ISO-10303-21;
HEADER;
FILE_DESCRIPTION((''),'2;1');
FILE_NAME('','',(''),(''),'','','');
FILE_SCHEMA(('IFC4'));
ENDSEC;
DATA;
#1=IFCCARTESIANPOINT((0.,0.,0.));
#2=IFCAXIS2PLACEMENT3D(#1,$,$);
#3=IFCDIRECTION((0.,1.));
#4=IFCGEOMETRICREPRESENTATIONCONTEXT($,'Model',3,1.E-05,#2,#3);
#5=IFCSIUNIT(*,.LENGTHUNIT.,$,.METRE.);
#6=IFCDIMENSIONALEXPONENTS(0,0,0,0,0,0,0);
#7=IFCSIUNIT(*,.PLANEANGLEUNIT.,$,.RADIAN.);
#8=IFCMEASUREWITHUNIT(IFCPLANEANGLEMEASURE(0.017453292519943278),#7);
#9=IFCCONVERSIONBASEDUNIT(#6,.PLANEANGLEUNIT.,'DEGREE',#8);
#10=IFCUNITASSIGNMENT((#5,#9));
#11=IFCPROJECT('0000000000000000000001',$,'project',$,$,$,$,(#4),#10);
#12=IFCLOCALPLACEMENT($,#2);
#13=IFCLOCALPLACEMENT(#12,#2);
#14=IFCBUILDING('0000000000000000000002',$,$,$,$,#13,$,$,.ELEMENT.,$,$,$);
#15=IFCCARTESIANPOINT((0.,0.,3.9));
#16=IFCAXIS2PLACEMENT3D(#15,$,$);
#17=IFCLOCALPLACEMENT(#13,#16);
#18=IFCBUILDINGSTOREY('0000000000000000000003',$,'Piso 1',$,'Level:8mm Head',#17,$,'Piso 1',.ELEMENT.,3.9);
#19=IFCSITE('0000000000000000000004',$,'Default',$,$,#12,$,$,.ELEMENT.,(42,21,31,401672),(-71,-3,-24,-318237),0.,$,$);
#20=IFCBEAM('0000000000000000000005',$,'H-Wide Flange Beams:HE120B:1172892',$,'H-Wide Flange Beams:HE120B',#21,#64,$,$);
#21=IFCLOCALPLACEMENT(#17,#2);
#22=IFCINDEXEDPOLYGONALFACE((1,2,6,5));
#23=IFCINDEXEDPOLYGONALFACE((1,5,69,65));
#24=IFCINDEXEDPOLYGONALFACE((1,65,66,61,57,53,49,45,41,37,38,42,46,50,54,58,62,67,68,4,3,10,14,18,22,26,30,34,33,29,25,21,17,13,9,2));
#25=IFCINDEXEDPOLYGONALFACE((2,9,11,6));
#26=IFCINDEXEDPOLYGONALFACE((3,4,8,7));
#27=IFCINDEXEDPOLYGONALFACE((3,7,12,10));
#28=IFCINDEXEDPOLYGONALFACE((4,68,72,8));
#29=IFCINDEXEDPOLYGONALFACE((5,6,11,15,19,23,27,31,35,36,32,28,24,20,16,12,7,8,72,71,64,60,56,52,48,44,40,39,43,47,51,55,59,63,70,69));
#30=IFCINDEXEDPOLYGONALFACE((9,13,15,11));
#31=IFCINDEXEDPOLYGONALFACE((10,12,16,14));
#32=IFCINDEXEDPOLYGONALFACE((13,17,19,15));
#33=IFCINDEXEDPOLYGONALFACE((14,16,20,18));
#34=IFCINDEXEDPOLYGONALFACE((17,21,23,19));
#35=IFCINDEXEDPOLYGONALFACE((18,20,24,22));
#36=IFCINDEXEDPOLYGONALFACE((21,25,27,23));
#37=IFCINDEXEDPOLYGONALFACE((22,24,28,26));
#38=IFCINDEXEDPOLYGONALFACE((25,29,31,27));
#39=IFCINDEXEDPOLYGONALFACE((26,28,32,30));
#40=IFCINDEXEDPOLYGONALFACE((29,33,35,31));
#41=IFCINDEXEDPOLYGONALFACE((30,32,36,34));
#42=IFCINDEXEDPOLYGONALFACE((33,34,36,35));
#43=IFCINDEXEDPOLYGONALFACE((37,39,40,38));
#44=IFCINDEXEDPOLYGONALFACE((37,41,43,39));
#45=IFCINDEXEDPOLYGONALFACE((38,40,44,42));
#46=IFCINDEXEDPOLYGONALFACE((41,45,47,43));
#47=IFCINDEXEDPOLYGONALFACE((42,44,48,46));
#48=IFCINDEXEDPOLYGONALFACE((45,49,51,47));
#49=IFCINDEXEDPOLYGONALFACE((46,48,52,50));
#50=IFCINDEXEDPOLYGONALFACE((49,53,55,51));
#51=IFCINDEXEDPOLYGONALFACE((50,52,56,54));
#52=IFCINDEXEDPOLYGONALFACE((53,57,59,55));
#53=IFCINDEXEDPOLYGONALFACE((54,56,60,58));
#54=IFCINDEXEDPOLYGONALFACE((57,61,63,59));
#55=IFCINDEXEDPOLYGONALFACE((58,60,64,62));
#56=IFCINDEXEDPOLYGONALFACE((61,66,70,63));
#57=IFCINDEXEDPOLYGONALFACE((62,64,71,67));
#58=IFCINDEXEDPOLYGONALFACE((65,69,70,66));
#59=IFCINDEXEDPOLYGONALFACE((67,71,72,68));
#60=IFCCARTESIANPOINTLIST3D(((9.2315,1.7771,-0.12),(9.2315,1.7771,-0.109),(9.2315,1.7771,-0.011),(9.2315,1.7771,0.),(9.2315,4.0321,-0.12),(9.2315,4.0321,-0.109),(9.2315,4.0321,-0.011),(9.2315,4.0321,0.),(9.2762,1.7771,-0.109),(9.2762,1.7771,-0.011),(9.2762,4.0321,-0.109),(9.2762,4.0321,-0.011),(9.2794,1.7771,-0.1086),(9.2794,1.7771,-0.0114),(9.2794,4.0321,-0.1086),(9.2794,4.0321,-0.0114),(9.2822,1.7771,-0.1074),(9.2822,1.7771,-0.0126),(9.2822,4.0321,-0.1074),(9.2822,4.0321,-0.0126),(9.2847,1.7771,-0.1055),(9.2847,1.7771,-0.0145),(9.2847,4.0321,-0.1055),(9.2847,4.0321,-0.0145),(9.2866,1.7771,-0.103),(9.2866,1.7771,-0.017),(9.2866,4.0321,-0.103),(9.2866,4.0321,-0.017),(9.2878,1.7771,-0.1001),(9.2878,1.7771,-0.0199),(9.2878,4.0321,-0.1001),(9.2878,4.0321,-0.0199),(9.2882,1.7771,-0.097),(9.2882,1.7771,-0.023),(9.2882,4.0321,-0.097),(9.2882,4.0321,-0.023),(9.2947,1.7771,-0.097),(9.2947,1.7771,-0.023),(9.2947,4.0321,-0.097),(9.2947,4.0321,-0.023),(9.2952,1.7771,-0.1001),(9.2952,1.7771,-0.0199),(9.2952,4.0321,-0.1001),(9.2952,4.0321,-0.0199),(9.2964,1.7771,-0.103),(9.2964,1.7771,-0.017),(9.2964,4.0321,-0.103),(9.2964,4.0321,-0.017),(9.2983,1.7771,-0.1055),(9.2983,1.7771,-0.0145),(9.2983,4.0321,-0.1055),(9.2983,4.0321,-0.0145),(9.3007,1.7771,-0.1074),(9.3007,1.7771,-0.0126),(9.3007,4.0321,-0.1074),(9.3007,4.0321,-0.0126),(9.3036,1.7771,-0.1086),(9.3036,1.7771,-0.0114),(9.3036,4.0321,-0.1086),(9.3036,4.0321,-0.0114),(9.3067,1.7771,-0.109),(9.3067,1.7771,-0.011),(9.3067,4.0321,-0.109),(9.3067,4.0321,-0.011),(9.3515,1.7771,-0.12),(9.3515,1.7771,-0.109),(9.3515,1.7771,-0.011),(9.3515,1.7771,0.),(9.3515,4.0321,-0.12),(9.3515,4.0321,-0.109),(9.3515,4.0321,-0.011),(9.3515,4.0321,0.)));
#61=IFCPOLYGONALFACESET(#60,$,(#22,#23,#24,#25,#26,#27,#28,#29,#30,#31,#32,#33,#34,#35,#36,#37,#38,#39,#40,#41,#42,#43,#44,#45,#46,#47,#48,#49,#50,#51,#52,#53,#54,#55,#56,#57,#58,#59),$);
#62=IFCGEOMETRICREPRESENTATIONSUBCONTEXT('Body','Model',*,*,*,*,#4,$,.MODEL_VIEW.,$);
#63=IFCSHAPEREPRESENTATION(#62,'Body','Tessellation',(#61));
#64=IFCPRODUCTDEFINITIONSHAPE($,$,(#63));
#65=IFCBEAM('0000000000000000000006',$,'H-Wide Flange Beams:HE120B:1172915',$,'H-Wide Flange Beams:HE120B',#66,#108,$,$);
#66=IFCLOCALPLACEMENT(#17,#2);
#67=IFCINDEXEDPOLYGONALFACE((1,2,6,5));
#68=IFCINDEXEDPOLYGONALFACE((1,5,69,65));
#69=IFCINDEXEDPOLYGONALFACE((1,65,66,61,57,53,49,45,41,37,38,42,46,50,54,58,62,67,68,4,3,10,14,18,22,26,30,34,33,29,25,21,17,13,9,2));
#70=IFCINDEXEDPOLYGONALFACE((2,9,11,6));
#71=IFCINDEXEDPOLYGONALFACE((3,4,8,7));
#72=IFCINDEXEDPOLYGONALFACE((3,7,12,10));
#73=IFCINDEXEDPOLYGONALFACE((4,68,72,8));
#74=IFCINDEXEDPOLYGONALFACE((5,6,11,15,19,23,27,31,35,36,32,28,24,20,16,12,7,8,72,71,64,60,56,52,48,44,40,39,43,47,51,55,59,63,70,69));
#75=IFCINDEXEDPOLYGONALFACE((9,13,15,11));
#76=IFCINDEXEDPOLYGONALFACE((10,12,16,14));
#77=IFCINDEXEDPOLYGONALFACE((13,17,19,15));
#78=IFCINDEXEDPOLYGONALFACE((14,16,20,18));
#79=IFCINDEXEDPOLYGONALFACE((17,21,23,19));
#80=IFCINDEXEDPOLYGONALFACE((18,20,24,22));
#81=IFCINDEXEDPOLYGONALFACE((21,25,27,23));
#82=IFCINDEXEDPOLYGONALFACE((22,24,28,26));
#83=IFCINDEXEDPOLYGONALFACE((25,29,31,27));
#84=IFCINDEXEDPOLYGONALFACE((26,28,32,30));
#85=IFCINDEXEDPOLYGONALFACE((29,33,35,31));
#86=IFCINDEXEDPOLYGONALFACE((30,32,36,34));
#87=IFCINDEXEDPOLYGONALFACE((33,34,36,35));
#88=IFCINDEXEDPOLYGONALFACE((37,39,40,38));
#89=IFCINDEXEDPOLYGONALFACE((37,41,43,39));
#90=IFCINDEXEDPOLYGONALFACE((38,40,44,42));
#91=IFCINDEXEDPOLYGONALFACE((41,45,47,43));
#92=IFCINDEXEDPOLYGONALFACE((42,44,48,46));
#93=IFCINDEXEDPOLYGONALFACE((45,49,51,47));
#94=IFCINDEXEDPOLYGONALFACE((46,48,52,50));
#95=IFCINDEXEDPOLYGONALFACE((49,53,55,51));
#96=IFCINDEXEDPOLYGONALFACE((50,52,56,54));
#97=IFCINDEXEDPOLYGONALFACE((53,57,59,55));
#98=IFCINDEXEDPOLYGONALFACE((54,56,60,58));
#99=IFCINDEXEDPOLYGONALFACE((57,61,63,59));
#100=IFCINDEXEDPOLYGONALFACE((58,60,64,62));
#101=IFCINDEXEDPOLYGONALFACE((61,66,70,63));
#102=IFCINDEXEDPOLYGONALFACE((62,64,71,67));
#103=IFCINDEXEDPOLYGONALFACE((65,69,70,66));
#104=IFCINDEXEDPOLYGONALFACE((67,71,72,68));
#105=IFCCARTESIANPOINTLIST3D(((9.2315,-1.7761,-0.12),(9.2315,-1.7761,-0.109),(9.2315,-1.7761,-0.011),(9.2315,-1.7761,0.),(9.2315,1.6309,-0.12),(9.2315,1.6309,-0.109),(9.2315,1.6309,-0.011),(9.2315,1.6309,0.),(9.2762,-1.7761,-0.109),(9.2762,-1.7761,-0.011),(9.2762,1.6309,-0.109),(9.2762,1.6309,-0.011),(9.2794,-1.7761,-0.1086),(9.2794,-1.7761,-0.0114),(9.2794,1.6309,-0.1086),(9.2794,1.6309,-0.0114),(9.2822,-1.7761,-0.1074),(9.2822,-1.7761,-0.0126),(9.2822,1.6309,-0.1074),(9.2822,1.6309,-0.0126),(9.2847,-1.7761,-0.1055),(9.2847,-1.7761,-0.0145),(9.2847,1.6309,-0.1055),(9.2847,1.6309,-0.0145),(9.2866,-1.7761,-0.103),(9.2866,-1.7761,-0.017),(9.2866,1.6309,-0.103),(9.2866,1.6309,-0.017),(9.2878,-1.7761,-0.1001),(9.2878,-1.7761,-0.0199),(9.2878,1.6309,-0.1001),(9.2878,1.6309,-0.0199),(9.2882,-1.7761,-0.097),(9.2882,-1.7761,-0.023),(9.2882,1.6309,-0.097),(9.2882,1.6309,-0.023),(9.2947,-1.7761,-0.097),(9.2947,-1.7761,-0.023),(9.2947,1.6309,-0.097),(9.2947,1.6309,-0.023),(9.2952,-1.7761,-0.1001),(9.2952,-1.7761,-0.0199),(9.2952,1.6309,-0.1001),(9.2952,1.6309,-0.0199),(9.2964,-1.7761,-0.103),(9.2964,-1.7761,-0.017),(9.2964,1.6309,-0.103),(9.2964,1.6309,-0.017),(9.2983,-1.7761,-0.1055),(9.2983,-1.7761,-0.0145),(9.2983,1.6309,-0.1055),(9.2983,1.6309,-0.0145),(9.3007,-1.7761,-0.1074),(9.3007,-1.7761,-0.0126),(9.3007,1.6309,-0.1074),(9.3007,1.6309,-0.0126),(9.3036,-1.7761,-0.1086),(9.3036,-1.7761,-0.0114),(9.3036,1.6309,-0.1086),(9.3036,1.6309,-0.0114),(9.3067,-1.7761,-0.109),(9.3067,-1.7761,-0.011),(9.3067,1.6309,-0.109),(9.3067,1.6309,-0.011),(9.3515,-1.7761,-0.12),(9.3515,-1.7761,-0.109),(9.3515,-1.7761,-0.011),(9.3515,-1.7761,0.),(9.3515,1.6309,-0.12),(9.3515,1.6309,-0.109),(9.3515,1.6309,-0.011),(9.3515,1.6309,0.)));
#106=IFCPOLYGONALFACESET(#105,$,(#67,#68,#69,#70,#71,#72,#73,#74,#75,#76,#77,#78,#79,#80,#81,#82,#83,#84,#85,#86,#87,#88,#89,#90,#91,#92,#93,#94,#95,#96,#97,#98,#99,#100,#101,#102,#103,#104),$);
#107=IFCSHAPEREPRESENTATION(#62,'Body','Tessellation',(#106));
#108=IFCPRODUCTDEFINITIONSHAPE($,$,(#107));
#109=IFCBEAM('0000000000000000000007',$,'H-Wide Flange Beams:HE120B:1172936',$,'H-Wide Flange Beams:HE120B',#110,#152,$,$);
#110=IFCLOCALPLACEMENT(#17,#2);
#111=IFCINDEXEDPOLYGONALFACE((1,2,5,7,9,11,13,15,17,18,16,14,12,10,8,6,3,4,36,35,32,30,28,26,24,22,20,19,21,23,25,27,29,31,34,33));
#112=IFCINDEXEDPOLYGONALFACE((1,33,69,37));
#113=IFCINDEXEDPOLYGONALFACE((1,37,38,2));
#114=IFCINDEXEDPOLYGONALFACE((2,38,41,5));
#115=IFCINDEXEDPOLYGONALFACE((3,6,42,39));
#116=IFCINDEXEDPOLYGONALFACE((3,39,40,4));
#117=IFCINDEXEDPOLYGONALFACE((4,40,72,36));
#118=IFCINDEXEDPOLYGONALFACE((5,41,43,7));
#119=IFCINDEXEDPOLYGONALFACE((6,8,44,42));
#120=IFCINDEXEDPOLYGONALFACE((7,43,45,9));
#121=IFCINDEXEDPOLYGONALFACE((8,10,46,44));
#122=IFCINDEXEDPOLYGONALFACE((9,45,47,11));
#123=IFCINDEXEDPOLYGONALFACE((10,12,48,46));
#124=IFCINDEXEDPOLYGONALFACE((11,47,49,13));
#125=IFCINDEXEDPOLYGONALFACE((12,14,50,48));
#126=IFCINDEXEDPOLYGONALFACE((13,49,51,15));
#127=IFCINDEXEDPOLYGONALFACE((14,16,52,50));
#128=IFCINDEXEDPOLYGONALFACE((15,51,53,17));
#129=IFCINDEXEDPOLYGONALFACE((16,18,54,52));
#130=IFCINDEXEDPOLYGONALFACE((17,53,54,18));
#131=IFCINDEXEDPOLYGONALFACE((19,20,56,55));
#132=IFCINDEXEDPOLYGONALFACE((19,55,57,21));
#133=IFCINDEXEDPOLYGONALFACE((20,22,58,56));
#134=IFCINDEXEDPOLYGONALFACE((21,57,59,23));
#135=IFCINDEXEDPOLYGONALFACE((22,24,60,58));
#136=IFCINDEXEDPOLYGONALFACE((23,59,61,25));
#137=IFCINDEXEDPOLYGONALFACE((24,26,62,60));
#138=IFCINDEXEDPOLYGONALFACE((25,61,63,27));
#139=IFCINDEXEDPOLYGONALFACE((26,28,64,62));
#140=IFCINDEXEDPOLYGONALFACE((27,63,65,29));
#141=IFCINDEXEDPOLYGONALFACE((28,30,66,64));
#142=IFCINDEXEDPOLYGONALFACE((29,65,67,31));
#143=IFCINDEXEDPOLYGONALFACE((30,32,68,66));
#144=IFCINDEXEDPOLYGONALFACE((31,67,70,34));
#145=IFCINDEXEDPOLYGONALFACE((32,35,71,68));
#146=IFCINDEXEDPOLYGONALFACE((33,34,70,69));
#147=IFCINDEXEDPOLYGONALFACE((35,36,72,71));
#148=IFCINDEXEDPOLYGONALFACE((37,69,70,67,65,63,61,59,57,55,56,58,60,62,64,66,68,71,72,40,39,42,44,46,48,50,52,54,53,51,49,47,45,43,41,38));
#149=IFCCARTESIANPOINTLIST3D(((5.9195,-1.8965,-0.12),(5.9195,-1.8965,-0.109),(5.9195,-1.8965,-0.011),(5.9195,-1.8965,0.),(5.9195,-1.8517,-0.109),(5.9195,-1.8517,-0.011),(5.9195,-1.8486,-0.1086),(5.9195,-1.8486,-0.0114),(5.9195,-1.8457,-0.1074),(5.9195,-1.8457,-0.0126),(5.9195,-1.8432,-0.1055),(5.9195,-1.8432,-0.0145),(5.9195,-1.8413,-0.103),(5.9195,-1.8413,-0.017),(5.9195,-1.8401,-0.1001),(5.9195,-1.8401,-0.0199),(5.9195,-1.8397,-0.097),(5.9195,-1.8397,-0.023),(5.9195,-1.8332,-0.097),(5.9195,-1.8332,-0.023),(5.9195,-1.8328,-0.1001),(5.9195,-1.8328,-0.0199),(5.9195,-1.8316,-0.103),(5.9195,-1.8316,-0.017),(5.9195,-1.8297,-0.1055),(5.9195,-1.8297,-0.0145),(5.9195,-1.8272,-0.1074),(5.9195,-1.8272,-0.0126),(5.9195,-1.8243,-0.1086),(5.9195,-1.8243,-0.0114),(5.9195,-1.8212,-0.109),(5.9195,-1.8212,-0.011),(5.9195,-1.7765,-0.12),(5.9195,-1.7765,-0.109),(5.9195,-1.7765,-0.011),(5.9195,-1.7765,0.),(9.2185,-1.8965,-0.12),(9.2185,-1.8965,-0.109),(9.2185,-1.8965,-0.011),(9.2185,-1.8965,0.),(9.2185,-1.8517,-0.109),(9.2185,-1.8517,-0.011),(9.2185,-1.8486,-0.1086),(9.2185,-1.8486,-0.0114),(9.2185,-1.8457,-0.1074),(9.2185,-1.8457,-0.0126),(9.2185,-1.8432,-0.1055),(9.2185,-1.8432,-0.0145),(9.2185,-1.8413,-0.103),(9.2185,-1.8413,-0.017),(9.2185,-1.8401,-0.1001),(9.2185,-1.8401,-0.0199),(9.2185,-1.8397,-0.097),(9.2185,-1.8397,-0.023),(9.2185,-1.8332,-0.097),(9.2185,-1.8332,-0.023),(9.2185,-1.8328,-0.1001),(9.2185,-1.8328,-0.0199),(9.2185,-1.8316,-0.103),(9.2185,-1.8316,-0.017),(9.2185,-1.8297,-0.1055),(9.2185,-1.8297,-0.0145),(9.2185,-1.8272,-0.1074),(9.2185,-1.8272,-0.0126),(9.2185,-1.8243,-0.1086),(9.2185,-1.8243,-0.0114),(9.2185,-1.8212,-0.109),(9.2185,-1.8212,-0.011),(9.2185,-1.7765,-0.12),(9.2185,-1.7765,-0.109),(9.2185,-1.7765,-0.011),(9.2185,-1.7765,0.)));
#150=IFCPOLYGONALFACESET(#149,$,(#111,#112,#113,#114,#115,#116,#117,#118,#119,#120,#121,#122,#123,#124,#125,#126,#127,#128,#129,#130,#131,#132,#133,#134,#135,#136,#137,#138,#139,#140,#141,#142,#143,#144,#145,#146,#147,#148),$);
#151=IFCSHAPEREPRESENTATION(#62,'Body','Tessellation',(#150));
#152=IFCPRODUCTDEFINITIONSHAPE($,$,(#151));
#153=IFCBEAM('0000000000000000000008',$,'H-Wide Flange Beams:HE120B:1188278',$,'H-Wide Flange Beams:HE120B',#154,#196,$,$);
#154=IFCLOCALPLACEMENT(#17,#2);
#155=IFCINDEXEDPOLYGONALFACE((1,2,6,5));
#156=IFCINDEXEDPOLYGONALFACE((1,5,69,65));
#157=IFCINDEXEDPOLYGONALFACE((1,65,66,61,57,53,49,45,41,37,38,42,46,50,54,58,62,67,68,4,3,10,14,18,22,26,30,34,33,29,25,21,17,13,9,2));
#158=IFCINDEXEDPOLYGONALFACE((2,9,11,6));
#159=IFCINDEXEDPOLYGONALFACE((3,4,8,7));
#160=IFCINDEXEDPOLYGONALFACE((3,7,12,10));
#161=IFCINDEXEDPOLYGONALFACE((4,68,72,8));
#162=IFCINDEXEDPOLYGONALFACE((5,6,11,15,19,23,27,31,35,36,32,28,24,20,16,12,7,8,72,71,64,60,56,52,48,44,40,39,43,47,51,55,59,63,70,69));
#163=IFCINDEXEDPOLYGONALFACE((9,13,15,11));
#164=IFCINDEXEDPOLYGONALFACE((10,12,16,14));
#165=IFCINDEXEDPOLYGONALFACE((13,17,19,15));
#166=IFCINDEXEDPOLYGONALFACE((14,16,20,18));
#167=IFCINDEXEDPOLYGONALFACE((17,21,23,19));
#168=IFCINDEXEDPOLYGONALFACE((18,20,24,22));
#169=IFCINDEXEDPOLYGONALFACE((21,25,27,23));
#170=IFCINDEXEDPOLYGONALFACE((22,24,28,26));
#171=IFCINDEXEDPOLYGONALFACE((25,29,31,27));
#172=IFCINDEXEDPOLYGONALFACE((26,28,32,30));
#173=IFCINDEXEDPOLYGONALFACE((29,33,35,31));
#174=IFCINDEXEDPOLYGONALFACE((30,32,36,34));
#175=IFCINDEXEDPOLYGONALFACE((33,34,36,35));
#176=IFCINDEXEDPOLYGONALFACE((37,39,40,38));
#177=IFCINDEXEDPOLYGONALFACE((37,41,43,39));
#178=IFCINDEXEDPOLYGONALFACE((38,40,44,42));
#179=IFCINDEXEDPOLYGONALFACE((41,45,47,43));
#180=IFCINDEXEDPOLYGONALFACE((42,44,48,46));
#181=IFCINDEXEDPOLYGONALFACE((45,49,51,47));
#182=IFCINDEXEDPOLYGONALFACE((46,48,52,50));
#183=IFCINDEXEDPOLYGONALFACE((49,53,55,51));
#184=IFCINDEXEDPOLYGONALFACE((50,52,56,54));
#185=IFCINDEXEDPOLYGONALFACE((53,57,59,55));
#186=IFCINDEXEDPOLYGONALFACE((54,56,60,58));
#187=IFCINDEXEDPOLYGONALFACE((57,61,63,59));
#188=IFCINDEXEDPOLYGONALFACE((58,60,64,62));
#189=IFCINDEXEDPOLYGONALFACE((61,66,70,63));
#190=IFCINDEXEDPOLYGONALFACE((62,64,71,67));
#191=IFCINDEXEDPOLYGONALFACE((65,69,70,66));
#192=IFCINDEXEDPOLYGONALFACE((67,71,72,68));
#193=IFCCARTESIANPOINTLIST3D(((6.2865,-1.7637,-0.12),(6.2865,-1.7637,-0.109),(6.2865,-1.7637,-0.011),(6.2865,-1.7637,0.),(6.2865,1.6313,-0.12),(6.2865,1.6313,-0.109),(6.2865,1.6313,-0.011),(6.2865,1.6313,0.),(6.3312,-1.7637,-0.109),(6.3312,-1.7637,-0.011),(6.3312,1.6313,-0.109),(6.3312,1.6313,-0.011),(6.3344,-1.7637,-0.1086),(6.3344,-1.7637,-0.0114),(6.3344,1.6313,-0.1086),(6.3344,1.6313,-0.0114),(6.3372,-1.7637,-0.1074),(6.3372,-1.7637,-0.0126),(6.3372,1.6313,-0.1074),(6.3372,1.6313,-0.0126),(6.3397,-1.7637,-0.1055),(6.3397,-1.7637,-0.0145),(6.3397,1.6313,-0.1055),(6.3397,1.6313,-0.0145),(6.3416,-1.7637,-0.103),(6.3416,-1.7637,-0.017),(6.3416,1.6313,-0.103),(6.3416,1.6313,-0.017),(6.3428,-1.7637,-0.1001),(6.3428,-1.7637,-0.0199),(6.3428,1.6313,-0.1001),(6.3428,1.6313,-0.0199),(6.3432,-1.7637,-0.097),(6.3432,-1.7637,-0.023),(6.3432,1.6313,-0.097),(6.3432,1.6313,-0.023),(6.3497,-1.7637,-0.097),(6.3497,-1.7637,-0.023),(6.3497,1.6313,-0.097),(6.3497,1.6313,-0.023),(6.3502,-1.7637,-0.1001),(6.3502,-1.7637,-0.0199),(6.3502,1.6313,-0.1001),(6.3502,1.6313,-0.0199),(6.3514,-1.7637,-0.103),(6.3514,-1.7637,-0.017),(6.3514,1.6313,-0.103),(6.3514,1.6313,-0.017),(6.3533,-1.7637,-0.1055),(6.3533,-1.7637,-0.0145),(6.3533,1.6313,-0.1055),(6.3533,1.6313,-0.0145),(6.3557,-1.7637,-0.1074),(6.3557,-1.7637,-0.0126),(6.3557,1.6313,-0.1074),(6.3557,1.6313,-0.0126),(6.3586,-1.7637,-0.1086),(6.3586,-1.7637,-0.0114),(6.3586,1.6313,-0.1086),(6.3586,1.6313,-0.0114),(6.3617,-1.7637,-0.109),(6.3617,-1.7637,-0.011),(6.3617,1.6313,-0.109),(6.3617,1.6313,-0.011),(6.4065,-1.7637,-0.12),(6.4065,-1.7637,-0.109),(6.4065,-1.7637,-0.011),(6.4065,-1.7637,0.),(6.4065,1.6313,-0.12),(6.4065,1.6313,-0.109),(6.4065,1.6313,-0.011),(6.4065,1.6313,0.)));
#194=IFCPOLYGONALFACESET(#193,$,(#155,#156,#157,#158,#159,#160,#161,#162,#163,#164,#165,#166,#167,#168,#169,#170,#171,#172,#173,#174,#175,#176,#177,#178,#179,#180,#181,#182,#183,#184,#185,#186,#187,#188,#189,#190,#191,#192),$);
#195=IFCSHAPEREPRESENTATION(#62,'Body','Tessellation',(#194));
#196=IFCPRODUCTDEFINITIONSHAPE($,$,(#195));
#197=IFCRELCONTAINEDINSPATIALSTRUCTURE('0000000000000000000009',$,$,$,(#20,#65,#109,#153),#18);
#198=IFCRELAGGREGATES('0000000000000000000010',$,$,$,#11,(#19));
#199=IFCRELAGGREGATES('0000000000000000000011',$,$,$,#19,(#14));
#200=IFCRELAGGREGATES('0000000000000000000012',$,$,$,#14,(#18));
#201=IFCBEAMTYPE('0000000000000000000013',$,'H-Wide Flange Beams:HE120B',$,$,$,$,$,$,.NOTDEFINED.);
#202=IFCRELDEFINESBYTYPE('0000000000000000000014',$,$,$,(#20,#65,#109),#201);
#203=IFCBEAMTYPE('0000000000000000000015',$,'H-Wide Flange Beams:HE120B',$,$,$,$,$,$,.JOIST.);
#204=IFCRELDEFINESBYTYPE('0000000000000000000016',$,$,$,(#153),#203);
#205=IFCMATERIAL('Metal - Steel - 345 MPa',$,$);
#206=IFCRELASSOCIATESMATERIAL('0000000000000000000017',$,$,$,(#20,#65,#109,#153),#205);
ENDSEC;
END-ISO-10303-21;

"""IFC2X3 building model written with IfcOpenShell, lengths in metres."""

from ifc_helpers import new_model, entity, si_unit, converted_unit, direction, frame, frame_2d, origin, place, context, subcontext, project, spatial, i_section, extrude, material, type_object, element, save


model = new_model("IFC2X3")

# Units and contexts
model_context = context("Model", 3, precision=1e-05, world=origin(), true_north=direction((0.0, 1.0)))
body_context = subcontext(model_context, "Body", "Model", "MODEL_VIEW")
ifc_project = project(units=[si_unit("LENGTHUNIT", "METRE"), converted_unit("PLANEANGLEUNIT", "DEGREE", entity("IfcPlaneAngleMeasure", 0.017453292519943278), si_unit("PLANEANGLEUNIT", "RADIAN"), dimensions=[0, 0, 0, 0, 0, 0, 0])], contexts=[model_context])

# Site, building, storey
site_placement = place(None, origin())
site = spatial("IfcSite", under=ifc_project, at=site_placement, Name="Default", CompositionType="ELEMENT", RefLatitude=(42, 21, 31, 401672), RefLongitude=(-71, -3, -24, -318237), RefElevation=0.0)
building_placement = place(site_placement, origin())
building = spatial("IfcBuilding", under=site, at=building_placement, CompositionType="ELEMENT")
storey_placement = place(building_placement, frame((0.0, 0.0, 3.9)))
storey = spatial("IfcBuildingStorey", under=building, at=storey_placement, Name="Piso 1", ObjectType="Level:8mm Head", LongName="Piso 1", CompositionType="ELEMENT", Elevation=3.9)

# Beams
ifc_material = material(Name="Metal - Steel - 345 MPa")
beam_type_1 = type_object("IfcBeamType", Name="H-Wide Flange Beams:HE120B", PredefinedType="NOTDEFINED")
beam_1_placement = place(storey_placement, frame((9.2915, 4.1052, 0.0), z_axis=(0.0, 0.0, 1.0), x_axis=(0.0, -1.0, 0.0)))
element("IfcBeam", 1, at=beam_1_placement, inside=storey, type_object=beam_type_1, material=ifc_material, Name="H-Wide Flange Beams:HE120B:1172892", ObjectType="H-Wide Flange Beams:HE120B", context=body_context, shape_type="SweptSolid", body=[
    extrude(i_section(OverallWidth=0.12, OverallDepth=0.12, WebThickness=0.0065, FlangeThickness=0.011, FilletRadius=0.012, at=frame_2d((0.0, 0.0), x_axis=(0.0, 1.0))), frame((0.073, 0.0, -0.06), z_axis=(1.0, 0.0, 0.0), x_axis=(0.0, 0.0, -1.0)), (0.0, 0.0, 1.0), 2.255),
])
beam_2_placement = place(storey_placement, frame((9.2915, 1.6922, 0.0), z_axis=(0.0, 0.0, 1.0), x_axis=(0.0, -1.0, 0.0)))
element("IfcBeam", 2, at=beam_2_placement, inside=storey, type_object=beam_type_1, material=ifc_material, Name="H-Wide Flange Beams:HE120B:1172915", ObjectType="H-Wide Flange Beams:HE120B", context=body_context, shape_type="SweptSolid", body=[
    extrude(i_section(OverallWidth=0.12, OverallDepth=0.12, WebThickness=0.0065, FlangeThickness=0.011, FilletRadius=0.012, at=frame_2d((0.0, 0.0), x_axis=(0.0, 1.0))), frame((0.0613, 0.0, -0.06), z_axis=(1.0, 0.0, 0.0), x_axis=(0.0, 0.0, -1.0)), (0.0, 0.0, 1.0), 3.407),
])
beam_3_placement = place(storey_placement, frame((9.2915, -1.8365, 0.0), z_axis=(0.0, 0.0, 1.0), x_axis=(-1.0, 0.0, 0.0)))
element("IfcBeam", 3, at=beam_3_placement, inside=storey, type_object=beam_type_1, material=ifc_material, Name="H-Wide Flange Beams:HE120B:1172936", ObjectType="H-Wide Flange Beams:HE120B", context=body_context, shape_type="SweptSolid", body=[
    extrude(i_section(OverallWidth=0.12, OverallDepth=0.12, WebThickness=0.0065, FlangeThickness=0.011, FilletRadius=0.012, at=frame_2d((0.0, 0.0), x_axis=(0.0, 1.0))), frame((0.073, 0.0, -0.06), z_axis=(1.0, 0.0, 0.0), x_axis=(0.0, 0.0, -1.0)), (0.0, 0.0, 1.0), 3.299),
])
beam_type_2 = type_object("IfcBeamType", Name="H-Wide Flange Beams:HE120B", PredefinedType="JOIST")
beam_4_placement = place(storey_placement, frame((6.3465, 1.7041, 0.0), z_axis=(0.0, 0.0, 1.0), x_axis=(0.0, -1.0, 0.0)))
element("IfcBeam", 4, at=beam_4_placement, inside=storey, type_object=beam_type_2, material=ifc_material, Name="H-Wide Flange Beams:HE120B:1188278", ObjectType="H-Wide Flange Beams:HE120B", context=body_context, shape_type="SweptSolid", body=[
    extrude(i_section(OverallWidth=0.12, OverallDepth=0.12, WebThickness=0.0065, FlangeThickness=0.011, FilletRadius=0.012, at=frame_2d((0.0, 0.0), x_axis=(0.0, 1.0))), frame((0.0728, 0.0, -0.06), z_axis=(1.0, 0.0, 0.0), x_axis=(0.0, 0.0, -1.0)), (0.0, 0.0, 1.0), 3.395),
])

save(model, "model.ifc")
